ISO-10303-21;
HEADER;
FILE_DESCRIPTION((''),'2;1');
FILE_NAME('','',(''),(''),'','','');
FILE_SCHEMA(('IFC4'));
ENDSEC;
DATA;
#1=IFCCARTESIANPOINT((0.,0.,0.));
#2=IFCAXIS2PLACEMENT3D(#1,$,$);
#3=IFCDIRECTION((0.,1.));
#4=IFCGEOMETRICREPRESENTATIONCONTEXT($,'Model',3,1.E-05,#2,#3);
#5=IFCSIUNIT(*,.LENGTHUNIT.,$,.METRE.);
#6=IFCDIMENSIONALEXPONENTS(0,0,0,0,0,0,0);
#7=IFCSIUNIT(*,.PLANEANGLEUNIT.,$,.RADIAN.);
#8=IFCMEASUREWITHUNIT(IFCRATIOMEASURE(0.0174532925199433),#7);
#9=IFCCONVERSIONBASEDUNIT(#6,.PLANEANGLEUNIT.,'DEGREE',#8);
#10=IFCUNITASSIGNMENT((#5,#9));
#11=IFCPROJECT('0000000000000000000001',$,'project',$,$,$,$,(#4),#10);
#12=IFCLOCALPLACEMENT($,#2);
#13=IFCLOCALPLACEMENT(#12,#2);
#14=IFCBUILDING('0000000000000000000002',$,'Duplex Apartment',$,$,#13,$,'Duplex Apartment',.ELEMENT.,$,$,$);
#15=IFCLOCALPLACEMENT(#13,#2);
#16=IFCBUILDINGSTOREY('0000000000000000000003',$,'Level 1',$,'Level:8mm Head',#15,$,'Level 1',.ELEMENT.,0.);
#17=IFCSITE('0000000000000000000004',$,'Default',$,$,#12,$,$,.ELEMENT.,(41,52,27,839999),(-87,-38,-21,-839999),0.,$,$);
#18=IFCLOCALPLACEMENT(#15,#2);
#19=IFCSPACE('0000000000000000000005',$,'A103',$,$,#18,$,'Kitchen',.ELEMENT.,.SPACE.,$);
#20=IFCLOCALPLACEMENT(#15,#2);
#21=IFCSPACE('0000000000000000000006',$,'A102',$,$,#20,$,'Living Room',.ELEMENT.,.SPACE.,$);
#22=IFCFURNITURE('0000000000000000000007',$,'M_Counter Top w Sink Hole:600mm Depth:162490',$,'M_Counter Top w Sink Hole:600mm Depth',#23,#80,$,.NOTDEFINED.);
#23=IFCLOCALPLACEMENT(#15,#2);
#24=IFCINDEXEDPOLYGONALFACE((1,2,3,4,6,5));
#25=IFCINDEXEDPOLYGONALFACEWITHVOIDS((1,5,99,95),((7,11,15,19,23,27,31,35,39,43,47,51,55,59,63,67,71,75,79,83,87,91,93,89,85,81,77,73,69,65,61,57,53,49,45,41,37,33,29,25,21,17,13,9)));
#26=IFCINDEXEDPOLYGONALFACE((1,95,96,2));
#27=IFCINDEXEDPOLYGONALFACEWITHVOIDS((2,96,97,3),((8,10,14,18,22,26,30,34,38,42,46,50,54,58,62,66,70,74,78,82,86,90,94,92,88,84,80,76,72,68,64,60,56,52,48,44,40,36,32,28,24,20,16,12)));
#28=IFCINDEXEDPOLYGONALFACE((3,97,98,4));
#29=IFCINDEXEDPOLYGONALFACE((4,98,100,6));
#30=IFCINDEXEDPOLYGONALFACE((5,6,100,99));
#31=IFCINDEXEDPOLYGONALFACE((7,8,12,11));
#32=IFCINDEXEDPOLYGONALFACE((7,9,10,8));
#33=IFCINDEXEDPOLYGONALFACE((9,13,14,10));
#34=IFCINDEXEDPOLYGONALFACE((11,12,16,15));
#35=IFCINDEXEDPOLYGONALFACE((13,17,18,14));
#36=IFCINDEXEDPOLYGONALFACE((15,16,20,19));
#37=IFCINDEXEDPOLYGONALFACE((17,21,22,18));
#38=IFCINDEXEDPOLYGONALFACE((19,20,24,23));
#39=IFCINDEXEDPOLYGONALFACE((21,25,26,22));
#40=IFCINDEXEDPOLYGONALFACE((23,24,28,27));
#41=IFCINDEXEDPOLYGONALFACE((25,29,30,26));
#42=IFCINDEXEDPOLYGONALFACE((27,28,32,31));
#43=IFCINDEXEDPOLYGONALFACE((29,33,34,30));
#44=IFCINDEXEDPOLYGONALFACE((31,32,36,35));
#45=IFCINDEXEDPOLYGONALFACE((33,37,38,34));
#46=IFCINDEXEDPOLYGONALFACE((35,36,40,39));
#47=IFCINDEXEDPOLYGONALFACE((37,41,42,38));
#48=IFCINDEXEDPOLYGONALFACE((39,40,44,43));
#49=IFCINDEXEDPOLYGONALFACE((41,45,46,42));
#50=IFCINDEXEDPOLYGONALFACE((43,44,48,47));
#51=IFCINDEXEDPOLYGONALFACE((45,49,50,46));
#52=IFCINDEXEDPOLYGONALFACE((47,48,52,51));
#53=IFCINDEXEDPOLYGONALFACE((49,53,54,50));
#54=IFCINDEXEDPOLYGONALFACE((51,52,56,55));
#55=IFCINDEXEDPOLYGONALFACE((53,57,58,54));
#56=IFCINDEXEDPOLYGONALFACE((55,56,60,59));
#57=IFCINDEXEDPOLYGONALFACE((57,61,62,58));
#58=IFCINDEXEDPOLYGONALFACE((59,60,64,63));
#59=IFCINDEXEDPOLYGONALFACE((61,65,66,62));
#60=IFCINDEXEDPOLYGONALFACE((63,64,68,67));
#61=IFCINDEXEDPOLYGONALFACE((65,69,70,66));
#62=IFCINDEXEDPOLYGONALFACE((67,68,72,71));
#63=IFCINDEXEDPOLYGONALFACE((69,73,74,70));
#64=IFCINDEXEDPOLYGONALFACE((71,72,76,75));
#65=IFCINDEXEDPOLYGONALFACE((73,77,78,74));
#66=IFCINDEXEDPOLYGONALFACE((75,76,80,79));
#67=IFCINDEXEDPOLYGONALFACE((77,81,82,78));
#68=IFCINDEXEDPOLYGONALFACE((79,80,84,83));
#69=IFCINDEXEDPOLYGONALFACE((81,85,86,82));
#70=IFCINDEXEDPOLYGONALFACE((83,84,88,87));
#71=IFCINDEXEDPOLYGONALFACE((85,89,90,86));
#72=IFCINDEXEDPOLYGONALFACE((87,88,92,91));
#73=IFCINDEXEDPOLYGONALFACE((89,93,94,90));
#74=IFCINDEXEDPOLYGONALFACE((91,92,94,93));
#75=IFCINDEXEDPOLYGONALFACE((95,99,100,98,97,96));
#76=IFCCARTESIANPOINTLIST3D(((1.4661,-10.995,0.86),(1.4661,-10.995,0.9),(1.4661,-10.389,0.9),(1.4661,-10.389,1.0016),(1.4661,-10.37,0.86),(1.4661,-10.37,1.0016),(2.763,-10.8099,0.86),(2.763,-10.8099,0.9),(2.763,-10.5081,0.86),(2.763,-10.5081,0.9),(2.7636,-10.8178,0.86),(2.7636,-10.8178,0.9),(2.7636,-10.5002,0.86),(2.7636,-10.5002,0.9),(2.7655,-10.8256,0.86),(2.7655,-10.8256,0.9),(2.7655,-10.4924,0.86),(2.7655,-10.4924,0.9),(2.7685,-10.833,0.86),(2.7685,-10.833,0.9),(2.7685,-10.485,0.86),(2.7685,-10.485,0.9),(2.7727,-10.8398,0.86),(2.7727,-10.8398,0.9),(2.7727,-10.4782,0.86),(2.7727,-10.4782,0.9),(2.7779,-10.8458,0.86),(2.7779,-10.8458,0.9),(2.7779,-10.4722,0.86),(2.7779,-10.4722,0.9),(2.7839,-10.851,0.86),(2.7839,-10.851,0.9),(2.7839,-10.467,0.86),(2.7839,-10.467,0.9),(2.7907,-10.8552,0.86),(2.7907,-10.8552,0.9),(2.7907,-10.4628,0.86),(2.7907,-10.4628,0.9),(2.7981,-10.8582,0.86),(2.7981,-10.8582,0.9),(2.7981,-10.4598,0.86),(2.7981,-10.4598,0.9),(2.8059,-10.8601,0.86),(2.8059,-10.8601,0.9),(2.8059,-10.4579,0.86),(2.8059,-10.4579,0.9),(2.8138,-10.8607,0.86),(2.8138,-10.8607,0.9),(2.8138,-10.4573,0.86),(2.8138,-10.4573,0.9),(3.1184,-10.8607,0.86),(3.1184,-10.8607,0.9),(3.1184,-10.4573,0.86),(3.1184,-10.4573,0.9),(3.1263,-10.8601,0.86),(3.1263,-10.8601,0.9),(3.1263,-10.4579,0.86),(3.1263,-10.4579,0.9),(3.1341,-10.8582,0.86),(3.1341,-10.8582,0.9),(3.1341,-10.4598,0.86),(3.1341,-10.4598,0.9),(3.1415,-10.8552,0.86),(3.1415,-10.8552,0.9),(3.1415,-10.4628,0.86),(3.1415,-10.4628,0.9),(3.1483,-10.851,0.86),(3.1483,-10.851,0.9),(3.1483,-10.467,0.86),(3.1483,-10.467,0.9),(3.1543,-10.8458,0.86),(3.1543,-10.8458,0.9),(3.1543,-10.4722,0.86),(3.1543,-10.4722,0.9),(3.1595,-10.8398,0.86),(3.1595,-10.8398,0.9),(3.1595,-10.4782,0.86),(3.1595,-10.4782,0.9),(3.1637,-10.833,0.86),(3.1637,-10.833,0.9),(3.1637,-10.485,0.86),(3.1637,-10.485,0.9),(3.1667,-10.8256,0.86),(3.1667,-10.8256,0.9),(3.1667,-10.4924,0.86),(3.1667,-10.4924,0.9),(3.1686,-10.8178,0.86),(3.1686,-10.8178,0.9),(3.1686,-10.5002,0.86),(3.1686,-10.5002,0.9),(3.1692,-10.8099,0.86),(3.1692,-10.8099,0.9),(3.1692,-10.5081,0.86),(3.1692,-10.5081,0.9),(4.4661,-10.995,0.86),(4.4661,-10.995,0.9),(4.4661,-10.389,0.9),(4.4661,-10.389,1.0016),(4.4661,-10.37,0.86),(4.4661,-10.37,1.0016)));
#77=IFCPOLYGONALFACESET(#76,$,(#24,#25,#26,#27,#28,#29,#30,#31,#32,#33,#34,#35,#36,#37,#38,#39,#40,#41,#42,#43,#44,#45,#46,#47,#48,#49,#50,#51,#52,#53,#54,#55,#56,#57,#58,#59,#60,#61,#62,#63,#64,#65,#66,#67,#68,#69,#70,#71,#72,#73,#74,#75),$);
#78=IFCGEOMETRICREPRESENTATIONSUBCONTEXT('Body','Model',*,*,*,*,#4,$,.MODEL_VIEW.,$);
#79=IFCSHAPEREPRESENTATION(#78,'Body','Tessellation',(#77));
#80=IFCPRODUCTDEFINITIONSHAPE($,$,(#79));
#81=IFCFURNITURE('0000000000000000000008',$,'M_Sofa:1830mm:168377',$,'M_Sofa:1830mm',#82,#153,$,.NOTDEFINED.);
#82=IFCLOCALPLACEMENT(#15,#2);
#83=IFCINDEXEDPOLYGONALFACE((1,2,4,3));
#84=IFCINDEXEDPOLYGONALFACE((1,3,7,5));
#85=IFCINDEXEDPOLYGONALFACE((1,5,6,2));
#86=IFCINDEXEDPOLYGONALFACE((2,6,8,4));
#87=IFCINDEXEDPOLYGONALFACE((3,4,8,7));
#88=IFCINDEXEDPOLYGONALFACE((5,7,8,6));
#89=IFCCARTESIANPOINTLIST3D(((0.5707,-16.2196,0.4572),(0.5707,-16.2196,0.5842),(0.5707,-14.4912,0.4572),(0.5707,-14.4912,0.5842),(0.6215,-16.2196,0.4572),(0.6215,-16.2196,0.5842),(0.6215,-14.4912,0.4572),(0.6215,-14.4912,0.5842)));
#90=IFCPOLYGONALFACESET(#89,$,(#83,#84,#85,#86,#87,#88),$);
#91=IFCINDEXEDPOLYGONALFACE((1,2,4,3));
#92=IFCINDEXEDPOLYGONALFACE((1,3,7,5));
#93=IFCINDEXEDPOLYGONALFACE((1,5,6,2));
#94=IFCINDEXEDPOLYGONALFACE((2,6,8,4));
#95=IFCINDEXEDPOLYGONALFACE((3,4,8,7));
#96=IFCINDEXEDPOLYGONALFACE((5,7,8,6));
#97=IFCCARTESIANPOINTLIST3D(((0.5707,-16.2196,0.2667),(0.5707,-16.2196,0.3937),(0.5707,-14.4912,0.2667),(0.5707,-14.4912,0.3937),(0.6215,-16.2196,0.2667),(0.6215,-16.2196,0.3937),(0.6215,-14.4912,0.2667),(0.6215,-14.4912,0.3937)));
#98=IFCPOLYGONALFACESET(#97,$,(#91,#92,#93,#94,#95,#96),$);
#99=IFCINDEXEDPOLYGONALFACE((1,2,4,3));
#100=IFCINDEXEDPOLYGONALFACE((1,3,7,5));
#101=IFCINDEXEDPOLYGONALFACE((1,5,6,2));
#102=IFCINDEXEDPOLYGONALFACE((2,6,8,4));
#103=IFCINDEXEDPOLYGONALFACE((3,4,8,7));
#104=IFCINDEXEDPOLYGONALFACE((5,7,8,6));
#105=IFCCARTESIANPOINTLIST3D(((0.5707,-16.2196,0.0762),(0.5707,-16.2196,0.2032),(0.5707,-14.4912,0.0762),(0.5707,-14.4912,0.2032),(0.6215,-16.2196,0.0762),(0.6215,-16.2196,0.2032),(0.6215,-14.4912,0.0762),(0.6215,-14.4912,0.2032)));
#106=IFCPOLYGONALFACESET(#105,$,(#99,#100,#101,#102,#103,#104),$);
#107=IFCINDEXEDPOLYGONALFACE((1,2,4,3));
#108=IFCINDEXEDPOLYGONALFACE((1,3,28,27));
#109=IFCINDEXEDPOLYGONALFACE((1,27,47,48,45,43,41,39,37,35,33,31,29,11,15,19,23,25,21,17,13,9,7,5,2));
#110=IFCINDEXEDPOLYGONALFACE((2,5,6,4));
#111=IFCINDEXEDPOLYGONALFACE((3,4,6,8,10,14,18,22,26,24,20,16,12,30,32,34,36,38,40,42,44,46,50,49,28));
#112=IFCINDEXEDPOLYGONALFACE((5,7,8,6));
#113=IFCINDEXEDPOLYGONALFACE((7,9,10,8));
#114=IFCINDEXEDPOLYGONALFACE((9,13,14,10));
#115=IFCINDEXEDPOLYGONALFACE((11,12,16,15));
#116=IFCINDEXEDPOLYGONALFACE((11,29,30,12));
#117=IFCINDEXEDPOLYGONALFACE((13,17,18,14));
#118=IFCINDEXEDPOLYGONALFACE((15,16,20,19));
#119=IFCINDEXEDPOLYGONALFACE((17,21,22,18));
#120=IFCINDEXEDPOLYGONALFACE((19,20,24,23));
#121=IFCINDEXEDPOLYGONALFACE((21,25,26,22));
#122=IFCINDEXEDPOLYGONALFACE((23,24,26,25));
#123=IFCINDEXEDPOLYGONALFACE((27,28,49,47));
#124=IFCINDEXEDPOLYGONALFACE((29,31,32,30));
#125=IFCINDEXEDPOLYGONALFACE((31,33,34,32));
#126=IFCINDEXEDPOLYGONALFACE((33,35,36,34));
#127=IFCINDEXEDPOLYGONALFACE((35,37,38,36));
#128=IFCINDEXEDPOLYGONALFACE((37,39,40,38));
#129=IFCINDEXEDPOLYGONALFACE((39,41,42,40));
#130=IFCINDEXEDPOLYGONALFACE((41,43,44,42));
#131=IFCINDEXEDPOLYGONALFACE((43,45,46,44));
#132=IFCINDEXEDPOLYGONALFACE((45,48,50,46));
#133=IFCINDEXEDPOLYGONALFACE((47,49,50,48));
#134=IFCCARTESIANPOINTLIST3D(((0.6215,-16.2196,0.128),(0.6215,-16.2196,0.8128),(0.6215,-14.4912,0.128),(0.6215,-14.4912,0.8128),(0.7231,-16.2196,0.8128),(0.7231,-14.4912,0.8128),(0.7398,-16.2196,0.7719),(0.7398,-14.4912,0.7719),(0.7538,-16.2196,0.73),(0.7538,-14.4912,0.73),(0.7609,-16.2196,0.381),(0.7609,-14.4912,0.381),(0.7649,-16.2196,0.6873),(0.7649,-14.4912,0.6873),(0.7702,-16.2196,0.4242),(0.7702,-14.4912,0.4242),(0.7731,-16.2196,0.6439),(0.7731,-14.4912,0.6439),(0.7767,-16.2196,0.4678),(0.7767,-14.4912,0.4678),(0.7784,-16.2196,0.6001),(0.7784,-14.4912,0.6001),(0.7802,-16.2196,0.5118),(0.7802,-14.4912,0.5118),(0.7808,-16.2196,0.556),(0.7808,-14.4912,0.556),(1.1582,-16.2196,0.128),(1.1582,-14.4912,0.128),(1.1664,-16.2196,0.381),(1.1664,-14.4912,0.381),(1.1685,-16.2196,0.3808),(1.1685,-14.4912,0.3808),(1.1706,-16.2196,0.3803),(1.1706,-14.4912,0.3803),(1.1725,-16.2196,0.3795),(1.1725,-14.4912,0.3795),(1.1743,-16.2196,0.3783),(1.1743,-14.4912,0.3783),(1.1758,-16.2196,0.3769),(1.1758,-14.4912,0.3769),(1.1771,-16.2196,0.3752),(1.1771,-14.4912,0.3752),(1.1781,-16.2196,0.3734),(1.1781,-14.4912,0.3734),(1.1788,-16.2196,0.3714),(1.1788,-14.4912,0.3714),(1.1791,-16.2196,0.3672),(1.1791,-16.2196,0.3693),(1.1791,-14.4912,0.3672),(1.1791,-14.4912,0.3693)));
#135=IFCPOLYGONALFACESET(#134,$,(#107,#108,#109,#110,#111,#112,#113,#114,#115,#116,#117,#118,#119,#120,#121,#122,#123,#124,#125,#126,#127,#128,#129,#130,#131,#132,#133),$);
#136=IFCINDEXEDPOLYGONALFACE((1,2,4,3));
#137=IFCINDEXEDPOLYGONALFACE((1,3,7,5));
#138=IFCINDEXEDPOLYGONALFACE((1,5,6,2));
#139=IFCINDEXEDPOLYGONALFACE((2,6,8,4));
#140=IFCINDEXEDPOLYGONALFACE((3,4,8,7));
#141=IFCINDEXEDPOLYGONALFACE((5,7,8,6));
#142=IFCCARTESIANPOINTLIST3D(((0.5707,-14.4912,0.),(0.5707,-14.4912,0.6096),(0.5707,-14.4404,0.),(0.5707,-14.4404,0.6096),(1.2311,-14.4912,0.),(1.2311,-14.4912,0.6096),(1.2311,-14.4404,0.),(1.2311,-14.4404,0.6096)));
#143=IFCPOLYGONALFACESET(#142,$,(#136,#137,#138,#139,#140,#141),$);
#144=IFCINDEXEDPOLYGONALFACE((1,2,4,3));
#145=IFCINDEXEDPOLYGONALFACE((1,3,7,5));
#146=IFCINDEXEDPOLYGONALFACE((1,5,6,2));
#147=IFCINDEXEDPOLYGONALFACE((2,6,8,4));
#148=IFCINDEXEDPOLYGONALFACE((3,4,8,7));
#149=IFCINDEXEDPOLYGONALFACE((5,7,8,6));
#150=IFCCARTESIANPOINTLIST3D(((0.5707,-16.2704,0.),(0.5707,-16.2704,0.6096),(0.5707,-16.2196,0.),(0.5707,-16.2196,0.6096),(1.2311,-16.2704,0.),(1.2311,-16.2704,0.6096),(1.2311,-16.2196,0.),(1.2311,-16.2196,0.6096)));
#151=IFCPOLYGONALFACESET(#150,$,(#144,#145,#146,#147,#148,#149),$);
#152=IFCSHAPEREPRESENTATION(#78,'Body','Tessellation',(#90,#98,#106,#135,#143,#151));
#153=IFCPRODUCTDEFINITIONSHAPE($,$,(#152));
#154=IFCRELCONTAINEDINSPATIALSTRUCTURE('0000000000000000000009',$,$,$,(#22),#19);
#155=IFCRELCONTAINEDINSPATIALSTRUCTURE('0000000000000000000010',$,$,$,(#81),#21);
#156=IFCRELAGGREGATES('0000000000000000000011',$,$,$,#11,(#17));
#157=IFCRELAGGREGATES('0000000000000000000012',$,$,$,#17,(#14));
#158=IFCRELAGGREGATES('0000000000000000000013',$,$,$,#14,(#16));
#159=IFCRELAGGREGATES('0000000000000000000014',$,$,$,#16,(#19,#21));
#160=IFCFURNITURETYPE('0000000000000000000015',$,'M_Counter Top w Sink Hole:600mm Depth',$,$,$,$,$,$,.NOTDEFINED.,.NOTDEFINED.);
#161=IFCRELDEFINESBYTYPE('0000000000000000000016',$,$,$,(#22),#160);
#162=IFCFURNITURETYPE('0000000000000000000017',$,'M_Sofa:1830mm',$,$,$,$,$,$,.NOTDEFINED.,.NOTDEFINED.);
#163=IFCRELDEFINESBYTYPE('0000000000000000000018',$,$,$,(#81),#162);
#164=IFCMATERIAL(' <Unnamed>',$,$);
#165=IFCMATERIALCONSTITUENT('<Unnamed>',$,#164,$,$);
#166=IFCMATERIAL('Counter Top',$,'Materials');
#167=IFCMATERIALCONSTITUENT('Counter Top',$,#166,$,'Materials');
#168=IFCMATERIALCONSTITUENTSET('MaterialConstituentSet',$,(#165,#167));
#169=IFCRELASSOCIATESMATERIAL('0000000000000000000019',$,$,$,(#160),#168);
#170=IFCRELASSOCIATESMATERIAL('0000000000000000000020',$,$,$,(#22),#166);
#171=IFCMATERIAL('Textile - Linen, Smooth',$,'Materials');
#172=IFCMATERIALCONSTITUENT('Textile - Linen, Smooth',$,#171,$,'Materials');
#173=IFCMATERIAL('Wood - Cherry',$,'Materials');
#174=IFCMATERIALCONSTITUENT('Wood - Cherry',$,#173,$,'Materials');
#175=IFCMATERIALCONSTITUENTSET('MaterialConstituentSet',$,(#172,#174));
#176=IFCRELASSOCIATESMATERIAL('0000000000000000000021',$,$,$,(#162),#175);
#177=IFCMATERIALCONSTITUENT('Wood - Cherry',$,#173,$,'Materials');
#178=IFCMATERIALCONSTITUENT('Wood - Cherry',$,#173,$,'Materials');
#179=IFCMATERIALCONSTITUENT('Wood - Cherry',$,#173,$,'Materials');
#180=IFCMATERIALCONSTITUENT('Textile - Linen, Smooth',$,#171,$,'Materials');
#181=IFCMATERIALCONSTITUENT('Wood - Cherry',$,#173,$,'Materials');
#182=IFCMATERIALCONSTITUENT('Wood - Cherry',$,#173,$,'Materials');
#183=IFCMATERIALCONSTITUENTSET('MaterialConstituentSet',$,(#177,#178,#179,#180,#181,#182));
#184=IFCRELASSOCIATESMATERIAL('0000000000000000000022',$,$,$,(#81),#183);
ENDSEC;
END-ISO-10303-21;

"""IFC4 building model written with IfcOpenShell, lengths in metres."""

from ifc_helpers import new_model, entity, si_unit, converted_unit, direction, frame, origin, place, context, subcontext, project, spatial, indexed_curve, outline, extrude, source, transform, mapped, material, constituent, constituent_set, type_object, type_shapes, element, save


model = new_model("IFC4")

# Units and contexts
model_context = context("Model", 3, precision=1e-05, world=origin(), true_north=direction((0.0, 1.0)))
body_context = subcontext(model_context, "Body", "Model", "MODEL_VIEW")
ifc_project = project(units=[si_unit("LENGTHUNIT", "METRE"), converted_unit("PLANEANGLEUNIT", "DEGREE", entity("IfcRatioMeasure", 0.0174532925199433), si_unit("PLANEANGLEUNIT", "RADIAN"), dimensions=[0, 0, 0, 0, 0, 0, 0])], contexts=[model_context])

# Site, building, storey
site_placement = place(None, origin())
site = spatial("IfcSite", under=ifc_project, at=site_placement, Name="Default", CompositionType="ELEMENT", RefLatitude=(41, 52, 27, 839999), RefLongitude=(-87, -38, -21, -839999), RefElevation=0.0)
building_placement = place(site_placement, origin())
building = spatial("IfcBuilding", under=site, at=building_placement, Name="Duplex Apartment", LongName="Duplex Apartment", CompositionType="ELEMENT")
storey_placement = place(building_placement, origin())
storey = spatial("IfcBuildingStorey", under=building, at=storey_placement, Name="Level 1", ObjectType="Level:8mm Head", LongName="Level 1", CompositionType="ELEMENT", Elevation=0.0)

# Shared definitions
space_1_placement = place(storey_placement, origin())
space_1 = spatial("IfcSpace", under=storey, at=space_1_placement, Name="A103", LongName="Kitchen", CompositionType="ELEMENT", PredefinedType="SPACE")

# Shared definitions
ifc_material_1 = material(Name="Counter Top", Category="Materials")
ifc_material_2 = material(Name=" <Unnamed>")

# Furniture, opening
ifc_constituent_1 = constituent(ifc_material_2, Name="<Unnamed>")
ifc_constituent_2 = constituent(ifc_material_1, Name="Counter Top", Category="Materials")
ifc_constituent_set_1 = constituent_set(constituents=[ifc_constituent_1, ifc_constituent_2], Name="MaterialConstituentSet")
furniture_type_1 = type_object("IfcFurnitureType", Name="M_Counter Top w Sink Hole:600mm Depth", AssemblyPlace="NOTDEFINED", PredefinedType="NOTDEFINED", material=ifc_constituent_set_1)
shared_shape_1 = source(origin(), body_context, "Body", "SweptSolid", [
    extrude(outline(indexed_curve([(-0.0605, -0.2147), (0.0811, -0.2147), (0.0811, -0.1956), (-0.0205, -0.1956), (-0.0205, 0.4103), (-0.0605, 0.4103), (-0.0605, -0.2147)], self_intersect=False)), frame((-1.2005, -0.2147, 0.9205), z_axis=(1.0, 0.0, 0.0), x_axis=(0.0, 0.0, 1.0)), (0.0, 0.0, 1.0), 3.0),
])
type_shapes(furniture_type_1, [shared_shape_1])
furniture_1_placement = place(space_1_placement, frame((2.6666, -10.37, 0.0)))
furniture_1 = element("IfcFurniture", 1, at=furniture_1_placement, inside=space_1, type_object=furniture_type_1, material=ifc_material_1, Name="M_Counter Top w Sink Hole:600mm Depth:162490", ObjectType="M_Counter Top w Sink Hole:600mm Depth", PredefinedType="NOTDEFINED", context=body_context, shape_type="MappedRepresentation", body=[
    mapped(shared_shape_1, transform((0.0, 0.0, 0.0), scale=1.0)),
])
opening_1_placement = place(storey_placement, frame((2.6666, -10.37, 0.0)))
element("IfcOpeningElement", 2, at=opening_1_placement, cuts=furniture_1, ObjectType="Opening", PredefinedType="OPENING", context=body_context, shape_type="SweptSolid", body=[
    extrude(outline(indexed_curve([(-0.1523, -0.2017), (0.1523, -0.2017), (0.1602, -0.2011), (0.168, -0.1992), (0.1754, -0.1962), (0.1822, -0.192), (0.1882, -0.1868), (0.1934, -0.1808), (0.1976, -0.174), (0.2006, -0.1666), (0.2025, -0.1588), (0.2031, -0.1509), (0.2031, 0.1509), (0.2025, 0.1588), (0.2006, 0.1666), (0.1976, 0.174), (0.1934, 0.1808), (0.1882, 0.1868), (0.1822, 0.192), (0.1754, 0.1962), (0.168, 0.1992), (0.1602, 0.2011), (0.1523, 0.2017), (-0.1523, 0.2017), (-0.1602, 0.2011), (-0.168, 0.1992), (-0.1754, 0.1962), (-0.1822, 0.192), (-0.1882, 0.1868), (-0.1934, 0.1808), (-0.1976, 0.174), (-0.2006, 0.1666), (-0.2025, 0.1588), (-0.2031, 0.1509), (-0.2031, -0.1509), (-0.2025, -0.1588), (-0.2006, -0.1666), (-0.1976, -0.174), (-0.1934, -0.1808), (-0.1882, -0.1868), (-0.1822, -0.192), (-0.1754, -0.1962), (-0.168, -0.1992), (-0.1602, -0.2011), (-0.1523, -0.2017)], self_intersect=False)), frame((0.2995, -0.289, 0.86), z_axis=(0.0, 0.0, 1.0), x_axis=(-1.0, 0.0, 0.0)), (0.0, 0.0, 1.0), 0.04),
])

# Shared definitions
space_2_placement = place(storey_placement, origin())
space_2 = spatial("IfcSpace", under=storey, at=space_2_placement, Name="A102", LongName="Living Room", CompositionType="ELEMENT", PredefinedType="SPACE")

# Furniture
ifc_material_3 = material(Name="Wood - Cherry", Category="Materials")
ifc_constituent_3 = constituent(ifc_material_3, Name="Wood - Cherry", Category="Materials")
ifc_constituent_4 = constituent(ifc_material_3, Name="Wood - Cherry", Category="Materials")
ifc_constituent_5 = constituent(ifc_material_3, Name="Wood - Cherry", Category="Materials")
ifc_material_4 = material(Name="Textile - Linen, Smooth", Category="Materials")
ifc_constituent_6 = constituent(ifc_material_4, Name="Textile - Linen, Smooth", Category="Materials")
ifc_constituent_7 = constituent(ifc_material_3, Name="Wood - Cherry", Category="Materials")
ifc_constituent_8 = constituent(ifc_material_3, Name="Wood - Cherry", Category="Materials")
ifc_constituent_set_2 = constituent_set(constituents=[ifc_constituent_3, ifc_constituent_4, ifc_constituent_5, ifc_constituent_6, ifc_constituent_7, ifc_constituent_8], Name="MaterialConstituentSet")
ifc_constituent_9 = constituent(ifc_material_4, Name="Textile - Linen, Smooth", Category="Materials")
ifc_constituent_10 = constituent(ifc_material_3, Name="Wood - Cherry", Category="Materials")
ifc_constituent_set_3 = constituent_set(constituents=[ifc_constituent_9, ifc_constituent_10], Name="MaterialConstituentSet")
furniture_type_2 = type_object("IfcFurnitureType", Name="M_Sofa:1830mm", AssemblyPlace="NOTDEFINED", PredefinedType="NOTDEFINED", material=ifc_constituent_set_3)
shared_shape_2 = source(origin(), body_context, "Body", "SweptSolid", [
    extrude(outline(indexed_curve([(-0.8642, -0.0254), (0.8642, -0.0254), (0.8642, 0.0254), (-0.8642, 0.0254), (-0.8642, -0.0254)], self_intersect=False)), frame((0.0704, 0.451, 0.4572)), (0.0, 0.0, 1.0), 0.127),
    extrude(outline(indexed_curve([(-0.8642, -0.0254), (0.8642, -0.0254), (0.8642, 0.0254), (-0.8642, 0.0254), (-0.8642, -0.0254)], self_intersect=False)), frame((0.0704, 0.451, 0.2667)), (0.0, 0.0, 1.0), 0.127),
    extrude(outline(indexed_curve([(-0.8642, -0.0254), (0.8642, -0.0254), (0.8642, 0.0254), (-0.8642, 0.0254), (-0.8642, -0.0254)], self_intersect=False)), frame((0.0704, 0.451, 0.0762)), (0.0, 0.0, 1.0), 0.127),
    extrude(outline(indexed_curve([(-0.1292, 0.0491), (0.2763, 0.0491), (0.2784, 0.0493), (0.2805, 0.0498), (0.2824, 0.0506), (0.2842, 0.0518), (0.2857, 0.0532), (0.287, 0.0549), (0.288, 0.0567), (0.2887, 0.0587), (0.289, 0.0608), (0.289, 0.0629), (0.2681, 0.3021), (-0.2686, 0.3021), (-0.2686, -0.3827), (-0.167, -0.3827), (-0.1503, -0.3418), (-0.1363, -0.2999), (-0.1252, -0.2572), (-0.117, -0.2138), (-0.1117, -0.17), (-0.1093, -0.1259), (-0.1099, -0.0817), (-0.1134, -0.0377), (-0.1199, 0.006), (-0.1292, 0.0491)], self_intersect=False)), frame((-0.7938, 0.157, 0.4301), z_axis=(1.0, 0.0, 0.0), x_axis=(0.0, -1.0, 0.0)), (0.0, 0.0, 1.0), 1.7284),
    extrude(outline(indexed_curve([(-0.0254, -0.3302), (0.0254, -0.3302), (0.0254, 0.3302), (-0.0254, 0.3302), (-0.0254, -0.3302)], self_intersect=False)), frame((0.96, 0.1462, 0.0), z_axis=(0.0, 0.0, 1.0), x_axis=(-1.0, 0.0, 0.0)), (0.0, 0.0, 1.0), 0.6096),
    extrude(outline(indexed_curve([(-0.0254, -0.3302), (0.0254, -0.3302), (0.0254, 0.3302), (-0.0254, 0.3302), (-0.0254, -0.3302)], self_intersect=False)), frame((-0.8192, 0.1462, 0.0), z_axis=(0.0, 0.0, 1.0), x_axis=(-1.0, 0.0, 0.0)), (0.0, 0.0, 1.0), 0.6096),
])
type_shapes(furniture_type_2, [shared_shape_2])
furniture_2_placement = place(space_2_placement, frame((1.0471, -15.4258, 0.0), z_axis=(0.0, 0.0, 1.0), x_axis=(0.0, 1.0, 0.0)))
element("IfcFurniture", 3, at=furniture_2_placement, inside=space_2, type_object=furniture_type_2, material=ifc_constituent_set_2, Name="M_Sofa:1830mm:168377", ObjectType="M_Sofa:1830mm", PredefinedType="NOTDEFINED", context=body_context, shape_type="MappedRepresentation", body=[
    mapped(shared_shape_2, transform((0.0, 0.0, 0.0), scale=1.0)),
])

save(model, "model.ifc")
